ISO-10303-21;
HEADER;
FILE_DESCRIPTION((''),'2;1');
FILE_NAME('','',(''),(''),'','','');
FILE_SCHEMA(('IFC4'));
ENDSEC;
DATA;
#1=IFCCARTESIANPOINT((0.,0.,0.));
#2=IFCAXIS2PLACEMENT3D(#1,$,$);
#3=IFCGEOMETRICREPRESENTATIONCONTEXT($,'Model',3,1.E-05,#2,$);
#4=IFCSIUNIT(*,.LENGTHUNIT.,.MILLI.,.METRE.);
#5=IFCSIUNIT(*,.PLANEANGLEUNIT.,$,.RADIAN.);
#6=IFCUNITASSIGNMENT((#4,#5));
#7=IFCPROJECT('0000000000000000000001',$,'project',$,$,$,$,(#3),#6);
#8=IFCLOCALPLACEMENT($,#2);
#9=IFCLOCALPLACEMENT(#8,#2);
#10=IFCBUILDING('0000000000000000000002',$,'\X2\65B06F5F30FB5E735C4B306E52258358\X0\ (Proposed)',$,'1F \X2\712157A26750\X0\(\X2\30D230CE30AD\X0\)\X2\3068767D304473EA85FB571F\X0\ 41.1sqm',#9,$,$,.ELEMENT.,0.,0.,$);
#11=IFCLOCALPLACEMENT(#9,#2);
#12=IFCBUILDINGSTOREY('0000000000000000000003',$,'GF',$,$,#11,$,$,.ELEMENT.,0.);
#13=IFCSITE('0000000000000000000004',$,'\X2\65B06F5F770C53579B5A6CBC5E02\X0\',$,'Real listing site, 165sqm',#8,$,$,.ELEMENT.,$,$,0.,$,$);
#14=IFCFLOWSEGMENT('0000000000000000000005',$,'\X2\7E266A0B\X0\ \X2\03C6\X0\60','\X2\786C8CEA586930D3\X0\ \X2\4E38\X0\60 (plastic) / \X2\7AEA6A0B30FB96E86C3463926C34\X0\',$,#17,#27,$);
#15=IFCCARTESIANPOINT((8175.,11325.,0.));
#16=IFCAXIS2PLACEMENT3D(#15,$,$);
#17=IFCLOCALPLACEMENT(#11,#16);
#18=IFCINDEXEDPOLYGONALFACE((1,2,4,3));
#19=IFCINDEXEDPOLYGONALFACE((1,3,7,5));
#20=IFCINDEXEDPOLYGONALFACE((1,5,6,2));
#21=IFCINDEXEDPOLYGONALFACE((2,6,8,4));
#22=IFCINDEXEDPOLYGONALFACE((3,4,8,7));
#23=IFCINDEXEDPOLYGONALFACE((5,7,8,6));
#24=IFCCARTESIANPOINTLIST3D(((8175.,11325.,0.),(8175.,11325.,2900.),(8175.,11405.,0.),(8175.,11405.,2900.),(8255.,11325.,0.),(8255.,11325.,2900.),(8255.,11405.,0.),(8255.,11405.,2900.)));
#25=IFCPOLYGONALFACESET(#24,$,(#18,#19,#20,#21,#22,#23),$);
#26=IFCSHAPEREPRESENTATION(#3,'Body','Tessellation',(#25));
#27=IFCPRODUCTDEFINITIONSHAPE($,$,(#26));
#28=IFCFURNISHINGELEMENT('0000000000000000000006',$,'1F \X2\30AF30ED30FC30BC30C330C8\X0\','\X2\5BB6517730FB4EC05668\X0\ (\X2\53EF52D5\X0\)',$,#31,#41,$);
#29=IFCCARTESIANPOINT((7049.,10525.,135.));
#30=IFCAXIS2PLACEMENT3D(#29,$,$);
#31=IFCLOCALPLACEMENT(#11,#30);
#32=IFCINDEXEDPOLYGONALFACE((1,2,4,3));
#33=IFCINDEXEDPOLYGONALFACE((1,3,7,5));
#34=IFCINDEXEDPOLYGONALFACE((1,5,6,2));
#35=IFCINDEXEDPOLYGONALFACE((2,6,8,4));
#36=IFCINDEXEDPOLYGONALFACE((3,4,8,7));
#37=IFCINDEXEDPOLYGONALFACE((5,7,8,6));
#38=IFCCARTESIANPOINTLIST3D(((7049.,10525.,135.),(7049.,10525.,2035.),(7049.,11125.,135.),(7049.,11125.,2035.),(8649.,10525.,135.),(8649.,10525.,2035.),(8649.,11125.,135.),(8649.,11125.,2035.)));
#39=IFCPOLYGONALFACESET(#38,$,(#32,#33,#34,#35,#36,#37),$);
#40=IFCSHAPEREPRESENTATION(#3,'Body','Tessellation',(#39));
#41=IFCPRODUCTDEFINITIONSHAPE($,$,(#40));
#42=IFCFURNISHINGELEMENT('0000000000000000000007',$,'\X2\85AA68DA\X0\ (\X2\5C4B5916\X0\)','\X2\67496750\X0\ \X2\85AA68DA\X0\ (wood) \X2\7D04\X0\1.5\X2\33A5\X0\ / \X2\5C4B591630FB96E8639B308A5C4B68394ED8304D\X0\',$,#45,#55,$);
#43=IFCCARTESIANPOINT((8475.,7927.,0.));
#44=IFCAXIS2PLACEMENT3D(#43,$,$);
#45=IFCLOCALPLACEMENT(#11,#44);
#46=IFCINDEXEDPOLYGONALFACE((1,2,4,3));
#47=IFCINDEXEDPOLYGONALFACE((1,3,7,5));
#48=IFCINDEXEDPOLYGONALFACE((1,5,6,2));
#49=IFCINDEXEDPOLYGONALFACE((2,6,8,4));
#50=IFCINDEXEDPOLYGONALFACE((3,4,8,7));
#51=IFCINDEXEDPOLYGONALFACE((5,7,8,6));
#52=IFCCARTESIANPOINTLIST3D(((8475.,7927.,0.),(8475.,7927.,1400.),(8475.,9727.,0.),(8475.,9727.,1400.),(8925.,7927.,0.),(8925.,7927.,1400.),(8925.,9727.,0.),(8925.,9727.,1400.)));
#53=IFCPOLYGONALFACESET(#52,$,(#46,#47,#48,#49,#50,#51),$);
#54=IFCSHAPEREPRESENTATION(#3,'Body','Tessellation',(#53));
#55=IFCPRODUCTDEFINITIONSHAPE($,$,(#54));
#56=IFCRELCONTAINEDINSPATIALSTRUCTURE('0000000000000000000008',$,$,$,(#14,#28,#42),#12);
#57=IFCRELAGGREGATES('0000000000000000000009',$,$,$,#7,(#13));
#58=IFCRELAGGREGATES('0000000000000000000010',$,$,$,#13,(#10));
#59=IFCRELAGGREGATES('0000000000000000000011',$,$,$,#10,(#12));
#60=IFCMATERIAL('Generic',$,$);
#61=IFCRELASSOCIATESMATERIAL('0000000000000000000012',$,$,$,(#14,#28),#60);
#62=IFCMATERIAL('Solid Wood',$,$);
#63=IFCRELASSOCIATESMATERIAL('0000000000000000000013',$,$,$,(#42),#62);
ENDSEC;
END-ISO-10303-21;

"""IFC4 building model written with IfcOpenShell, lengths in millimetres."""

from ifc_helpers import new_model, si_unit, frame, frame_2d, origin, place, context, project, spatial, rectangle, extrude, material, element, save


model = new_model("IFC4")

# Units and contexts
model_context = context("Model", 3, precision=1e-05, world=origin())
ifc_project = project(units=[si_unit("LENGTHUNIT", "METRE", prefix="MILLI"), si_unit("PLANEANGLEUNIT", "RADIAN")], contexts=[model_context])

# Site, building, storey
site_placement = place(None, origin())
site = spatial("IfcSite", under=ifc_project, at=site_placement, Name="新潟県南魚沼市", ObjectType="Real listing site, 165sqm", CompositionType="ELEMENT", RefElevation=0.0)
building_placement = place(site_placement, origin())
building = spatial("IfcBuilding", under=site, at=building_placement, Name="新潟・平屋の別荘 (Proposed)", ObjectType="1F 無垢材(ヒノキ)と白い珪藻土 41.1sqm", CompositionType="ELEMENT", ElevationOfRefHeight=0.0, ElevationOfTerrain=0.0)
storey_placement = place(building_placement, origin())
storey = spatial("IfcBuildingStorey", under=building, at=storey_placement, Name="GF", CompositionType="ELEMENT", Elevation=0.0)

# Shared definitions
ifc_material_1 = material(Name="Solid Wood")

# Shared definitions
ifc_material_2 = material(Name="Generic")

# Flow segment
flow_segment_placement = place(storey_placement, frame((8175.0, 11325.0, 0.0)))
element("IfcFlowSegment", 1, at=flow_segment_placement, inside=storey, material=ifc_material_2, Name="縦樋 φ60", Description="硬質塩ビ 丸60 (plastic) / 竪樋・雨水排水", context=model_context, shape_type="SweptSolid", body=[
    extrude(rectangle(XDim=80.0, YDim=80.0, at=frame_2d((40.0, 40.0))), frame((8175.0, 11325.0, 0.0)), (0.0, 0.0, 1.0), 2900.0),
])

# Furnishing elements
furnishing_1_placement = place(storey_placement, frame((7049.0, 10525.0, 135.0)))
element("IfcFurnishingElement", 2, at=furnishing_1_placement, inside=storey, material=ifc_material_2, Name="1F クローゼット", Description="家具・什器 (可動)", context=model_context, shape_type="SweptSolid", body=[
    extrude(rectangle(XDim=1600.0, YDim=600.0, at=frame_2d((800.0, 300.0))), frame((7049.0, 10525.0, 135.0)), (0.0, 0.0, 1.0), 1900.0),
])
furnishing_2_placement = place(storey_placement, frame((8475.0, 7927.0, 0.0)))
element("IfcFurnishingElement", 3, at=furnishing_2_placement, inside=storey, material=ifc_material_1, Name="薪棚 (屋外)", Description="杉材 薪棚 (wood) 約1.5㎥ / 屋外・雨掛り屋根付き", context=model_context, shape_type="SweptSolid", body=[
    extrude(rectangle(XDim=450.0, YDim=1800.0, at=frame_2d((225.0, 900.0))), frame((8475.0, 7927.0, 0.0)), (0.0, 0.0, 1.0), 1400.0),
])

save(model, "model.ifc")
